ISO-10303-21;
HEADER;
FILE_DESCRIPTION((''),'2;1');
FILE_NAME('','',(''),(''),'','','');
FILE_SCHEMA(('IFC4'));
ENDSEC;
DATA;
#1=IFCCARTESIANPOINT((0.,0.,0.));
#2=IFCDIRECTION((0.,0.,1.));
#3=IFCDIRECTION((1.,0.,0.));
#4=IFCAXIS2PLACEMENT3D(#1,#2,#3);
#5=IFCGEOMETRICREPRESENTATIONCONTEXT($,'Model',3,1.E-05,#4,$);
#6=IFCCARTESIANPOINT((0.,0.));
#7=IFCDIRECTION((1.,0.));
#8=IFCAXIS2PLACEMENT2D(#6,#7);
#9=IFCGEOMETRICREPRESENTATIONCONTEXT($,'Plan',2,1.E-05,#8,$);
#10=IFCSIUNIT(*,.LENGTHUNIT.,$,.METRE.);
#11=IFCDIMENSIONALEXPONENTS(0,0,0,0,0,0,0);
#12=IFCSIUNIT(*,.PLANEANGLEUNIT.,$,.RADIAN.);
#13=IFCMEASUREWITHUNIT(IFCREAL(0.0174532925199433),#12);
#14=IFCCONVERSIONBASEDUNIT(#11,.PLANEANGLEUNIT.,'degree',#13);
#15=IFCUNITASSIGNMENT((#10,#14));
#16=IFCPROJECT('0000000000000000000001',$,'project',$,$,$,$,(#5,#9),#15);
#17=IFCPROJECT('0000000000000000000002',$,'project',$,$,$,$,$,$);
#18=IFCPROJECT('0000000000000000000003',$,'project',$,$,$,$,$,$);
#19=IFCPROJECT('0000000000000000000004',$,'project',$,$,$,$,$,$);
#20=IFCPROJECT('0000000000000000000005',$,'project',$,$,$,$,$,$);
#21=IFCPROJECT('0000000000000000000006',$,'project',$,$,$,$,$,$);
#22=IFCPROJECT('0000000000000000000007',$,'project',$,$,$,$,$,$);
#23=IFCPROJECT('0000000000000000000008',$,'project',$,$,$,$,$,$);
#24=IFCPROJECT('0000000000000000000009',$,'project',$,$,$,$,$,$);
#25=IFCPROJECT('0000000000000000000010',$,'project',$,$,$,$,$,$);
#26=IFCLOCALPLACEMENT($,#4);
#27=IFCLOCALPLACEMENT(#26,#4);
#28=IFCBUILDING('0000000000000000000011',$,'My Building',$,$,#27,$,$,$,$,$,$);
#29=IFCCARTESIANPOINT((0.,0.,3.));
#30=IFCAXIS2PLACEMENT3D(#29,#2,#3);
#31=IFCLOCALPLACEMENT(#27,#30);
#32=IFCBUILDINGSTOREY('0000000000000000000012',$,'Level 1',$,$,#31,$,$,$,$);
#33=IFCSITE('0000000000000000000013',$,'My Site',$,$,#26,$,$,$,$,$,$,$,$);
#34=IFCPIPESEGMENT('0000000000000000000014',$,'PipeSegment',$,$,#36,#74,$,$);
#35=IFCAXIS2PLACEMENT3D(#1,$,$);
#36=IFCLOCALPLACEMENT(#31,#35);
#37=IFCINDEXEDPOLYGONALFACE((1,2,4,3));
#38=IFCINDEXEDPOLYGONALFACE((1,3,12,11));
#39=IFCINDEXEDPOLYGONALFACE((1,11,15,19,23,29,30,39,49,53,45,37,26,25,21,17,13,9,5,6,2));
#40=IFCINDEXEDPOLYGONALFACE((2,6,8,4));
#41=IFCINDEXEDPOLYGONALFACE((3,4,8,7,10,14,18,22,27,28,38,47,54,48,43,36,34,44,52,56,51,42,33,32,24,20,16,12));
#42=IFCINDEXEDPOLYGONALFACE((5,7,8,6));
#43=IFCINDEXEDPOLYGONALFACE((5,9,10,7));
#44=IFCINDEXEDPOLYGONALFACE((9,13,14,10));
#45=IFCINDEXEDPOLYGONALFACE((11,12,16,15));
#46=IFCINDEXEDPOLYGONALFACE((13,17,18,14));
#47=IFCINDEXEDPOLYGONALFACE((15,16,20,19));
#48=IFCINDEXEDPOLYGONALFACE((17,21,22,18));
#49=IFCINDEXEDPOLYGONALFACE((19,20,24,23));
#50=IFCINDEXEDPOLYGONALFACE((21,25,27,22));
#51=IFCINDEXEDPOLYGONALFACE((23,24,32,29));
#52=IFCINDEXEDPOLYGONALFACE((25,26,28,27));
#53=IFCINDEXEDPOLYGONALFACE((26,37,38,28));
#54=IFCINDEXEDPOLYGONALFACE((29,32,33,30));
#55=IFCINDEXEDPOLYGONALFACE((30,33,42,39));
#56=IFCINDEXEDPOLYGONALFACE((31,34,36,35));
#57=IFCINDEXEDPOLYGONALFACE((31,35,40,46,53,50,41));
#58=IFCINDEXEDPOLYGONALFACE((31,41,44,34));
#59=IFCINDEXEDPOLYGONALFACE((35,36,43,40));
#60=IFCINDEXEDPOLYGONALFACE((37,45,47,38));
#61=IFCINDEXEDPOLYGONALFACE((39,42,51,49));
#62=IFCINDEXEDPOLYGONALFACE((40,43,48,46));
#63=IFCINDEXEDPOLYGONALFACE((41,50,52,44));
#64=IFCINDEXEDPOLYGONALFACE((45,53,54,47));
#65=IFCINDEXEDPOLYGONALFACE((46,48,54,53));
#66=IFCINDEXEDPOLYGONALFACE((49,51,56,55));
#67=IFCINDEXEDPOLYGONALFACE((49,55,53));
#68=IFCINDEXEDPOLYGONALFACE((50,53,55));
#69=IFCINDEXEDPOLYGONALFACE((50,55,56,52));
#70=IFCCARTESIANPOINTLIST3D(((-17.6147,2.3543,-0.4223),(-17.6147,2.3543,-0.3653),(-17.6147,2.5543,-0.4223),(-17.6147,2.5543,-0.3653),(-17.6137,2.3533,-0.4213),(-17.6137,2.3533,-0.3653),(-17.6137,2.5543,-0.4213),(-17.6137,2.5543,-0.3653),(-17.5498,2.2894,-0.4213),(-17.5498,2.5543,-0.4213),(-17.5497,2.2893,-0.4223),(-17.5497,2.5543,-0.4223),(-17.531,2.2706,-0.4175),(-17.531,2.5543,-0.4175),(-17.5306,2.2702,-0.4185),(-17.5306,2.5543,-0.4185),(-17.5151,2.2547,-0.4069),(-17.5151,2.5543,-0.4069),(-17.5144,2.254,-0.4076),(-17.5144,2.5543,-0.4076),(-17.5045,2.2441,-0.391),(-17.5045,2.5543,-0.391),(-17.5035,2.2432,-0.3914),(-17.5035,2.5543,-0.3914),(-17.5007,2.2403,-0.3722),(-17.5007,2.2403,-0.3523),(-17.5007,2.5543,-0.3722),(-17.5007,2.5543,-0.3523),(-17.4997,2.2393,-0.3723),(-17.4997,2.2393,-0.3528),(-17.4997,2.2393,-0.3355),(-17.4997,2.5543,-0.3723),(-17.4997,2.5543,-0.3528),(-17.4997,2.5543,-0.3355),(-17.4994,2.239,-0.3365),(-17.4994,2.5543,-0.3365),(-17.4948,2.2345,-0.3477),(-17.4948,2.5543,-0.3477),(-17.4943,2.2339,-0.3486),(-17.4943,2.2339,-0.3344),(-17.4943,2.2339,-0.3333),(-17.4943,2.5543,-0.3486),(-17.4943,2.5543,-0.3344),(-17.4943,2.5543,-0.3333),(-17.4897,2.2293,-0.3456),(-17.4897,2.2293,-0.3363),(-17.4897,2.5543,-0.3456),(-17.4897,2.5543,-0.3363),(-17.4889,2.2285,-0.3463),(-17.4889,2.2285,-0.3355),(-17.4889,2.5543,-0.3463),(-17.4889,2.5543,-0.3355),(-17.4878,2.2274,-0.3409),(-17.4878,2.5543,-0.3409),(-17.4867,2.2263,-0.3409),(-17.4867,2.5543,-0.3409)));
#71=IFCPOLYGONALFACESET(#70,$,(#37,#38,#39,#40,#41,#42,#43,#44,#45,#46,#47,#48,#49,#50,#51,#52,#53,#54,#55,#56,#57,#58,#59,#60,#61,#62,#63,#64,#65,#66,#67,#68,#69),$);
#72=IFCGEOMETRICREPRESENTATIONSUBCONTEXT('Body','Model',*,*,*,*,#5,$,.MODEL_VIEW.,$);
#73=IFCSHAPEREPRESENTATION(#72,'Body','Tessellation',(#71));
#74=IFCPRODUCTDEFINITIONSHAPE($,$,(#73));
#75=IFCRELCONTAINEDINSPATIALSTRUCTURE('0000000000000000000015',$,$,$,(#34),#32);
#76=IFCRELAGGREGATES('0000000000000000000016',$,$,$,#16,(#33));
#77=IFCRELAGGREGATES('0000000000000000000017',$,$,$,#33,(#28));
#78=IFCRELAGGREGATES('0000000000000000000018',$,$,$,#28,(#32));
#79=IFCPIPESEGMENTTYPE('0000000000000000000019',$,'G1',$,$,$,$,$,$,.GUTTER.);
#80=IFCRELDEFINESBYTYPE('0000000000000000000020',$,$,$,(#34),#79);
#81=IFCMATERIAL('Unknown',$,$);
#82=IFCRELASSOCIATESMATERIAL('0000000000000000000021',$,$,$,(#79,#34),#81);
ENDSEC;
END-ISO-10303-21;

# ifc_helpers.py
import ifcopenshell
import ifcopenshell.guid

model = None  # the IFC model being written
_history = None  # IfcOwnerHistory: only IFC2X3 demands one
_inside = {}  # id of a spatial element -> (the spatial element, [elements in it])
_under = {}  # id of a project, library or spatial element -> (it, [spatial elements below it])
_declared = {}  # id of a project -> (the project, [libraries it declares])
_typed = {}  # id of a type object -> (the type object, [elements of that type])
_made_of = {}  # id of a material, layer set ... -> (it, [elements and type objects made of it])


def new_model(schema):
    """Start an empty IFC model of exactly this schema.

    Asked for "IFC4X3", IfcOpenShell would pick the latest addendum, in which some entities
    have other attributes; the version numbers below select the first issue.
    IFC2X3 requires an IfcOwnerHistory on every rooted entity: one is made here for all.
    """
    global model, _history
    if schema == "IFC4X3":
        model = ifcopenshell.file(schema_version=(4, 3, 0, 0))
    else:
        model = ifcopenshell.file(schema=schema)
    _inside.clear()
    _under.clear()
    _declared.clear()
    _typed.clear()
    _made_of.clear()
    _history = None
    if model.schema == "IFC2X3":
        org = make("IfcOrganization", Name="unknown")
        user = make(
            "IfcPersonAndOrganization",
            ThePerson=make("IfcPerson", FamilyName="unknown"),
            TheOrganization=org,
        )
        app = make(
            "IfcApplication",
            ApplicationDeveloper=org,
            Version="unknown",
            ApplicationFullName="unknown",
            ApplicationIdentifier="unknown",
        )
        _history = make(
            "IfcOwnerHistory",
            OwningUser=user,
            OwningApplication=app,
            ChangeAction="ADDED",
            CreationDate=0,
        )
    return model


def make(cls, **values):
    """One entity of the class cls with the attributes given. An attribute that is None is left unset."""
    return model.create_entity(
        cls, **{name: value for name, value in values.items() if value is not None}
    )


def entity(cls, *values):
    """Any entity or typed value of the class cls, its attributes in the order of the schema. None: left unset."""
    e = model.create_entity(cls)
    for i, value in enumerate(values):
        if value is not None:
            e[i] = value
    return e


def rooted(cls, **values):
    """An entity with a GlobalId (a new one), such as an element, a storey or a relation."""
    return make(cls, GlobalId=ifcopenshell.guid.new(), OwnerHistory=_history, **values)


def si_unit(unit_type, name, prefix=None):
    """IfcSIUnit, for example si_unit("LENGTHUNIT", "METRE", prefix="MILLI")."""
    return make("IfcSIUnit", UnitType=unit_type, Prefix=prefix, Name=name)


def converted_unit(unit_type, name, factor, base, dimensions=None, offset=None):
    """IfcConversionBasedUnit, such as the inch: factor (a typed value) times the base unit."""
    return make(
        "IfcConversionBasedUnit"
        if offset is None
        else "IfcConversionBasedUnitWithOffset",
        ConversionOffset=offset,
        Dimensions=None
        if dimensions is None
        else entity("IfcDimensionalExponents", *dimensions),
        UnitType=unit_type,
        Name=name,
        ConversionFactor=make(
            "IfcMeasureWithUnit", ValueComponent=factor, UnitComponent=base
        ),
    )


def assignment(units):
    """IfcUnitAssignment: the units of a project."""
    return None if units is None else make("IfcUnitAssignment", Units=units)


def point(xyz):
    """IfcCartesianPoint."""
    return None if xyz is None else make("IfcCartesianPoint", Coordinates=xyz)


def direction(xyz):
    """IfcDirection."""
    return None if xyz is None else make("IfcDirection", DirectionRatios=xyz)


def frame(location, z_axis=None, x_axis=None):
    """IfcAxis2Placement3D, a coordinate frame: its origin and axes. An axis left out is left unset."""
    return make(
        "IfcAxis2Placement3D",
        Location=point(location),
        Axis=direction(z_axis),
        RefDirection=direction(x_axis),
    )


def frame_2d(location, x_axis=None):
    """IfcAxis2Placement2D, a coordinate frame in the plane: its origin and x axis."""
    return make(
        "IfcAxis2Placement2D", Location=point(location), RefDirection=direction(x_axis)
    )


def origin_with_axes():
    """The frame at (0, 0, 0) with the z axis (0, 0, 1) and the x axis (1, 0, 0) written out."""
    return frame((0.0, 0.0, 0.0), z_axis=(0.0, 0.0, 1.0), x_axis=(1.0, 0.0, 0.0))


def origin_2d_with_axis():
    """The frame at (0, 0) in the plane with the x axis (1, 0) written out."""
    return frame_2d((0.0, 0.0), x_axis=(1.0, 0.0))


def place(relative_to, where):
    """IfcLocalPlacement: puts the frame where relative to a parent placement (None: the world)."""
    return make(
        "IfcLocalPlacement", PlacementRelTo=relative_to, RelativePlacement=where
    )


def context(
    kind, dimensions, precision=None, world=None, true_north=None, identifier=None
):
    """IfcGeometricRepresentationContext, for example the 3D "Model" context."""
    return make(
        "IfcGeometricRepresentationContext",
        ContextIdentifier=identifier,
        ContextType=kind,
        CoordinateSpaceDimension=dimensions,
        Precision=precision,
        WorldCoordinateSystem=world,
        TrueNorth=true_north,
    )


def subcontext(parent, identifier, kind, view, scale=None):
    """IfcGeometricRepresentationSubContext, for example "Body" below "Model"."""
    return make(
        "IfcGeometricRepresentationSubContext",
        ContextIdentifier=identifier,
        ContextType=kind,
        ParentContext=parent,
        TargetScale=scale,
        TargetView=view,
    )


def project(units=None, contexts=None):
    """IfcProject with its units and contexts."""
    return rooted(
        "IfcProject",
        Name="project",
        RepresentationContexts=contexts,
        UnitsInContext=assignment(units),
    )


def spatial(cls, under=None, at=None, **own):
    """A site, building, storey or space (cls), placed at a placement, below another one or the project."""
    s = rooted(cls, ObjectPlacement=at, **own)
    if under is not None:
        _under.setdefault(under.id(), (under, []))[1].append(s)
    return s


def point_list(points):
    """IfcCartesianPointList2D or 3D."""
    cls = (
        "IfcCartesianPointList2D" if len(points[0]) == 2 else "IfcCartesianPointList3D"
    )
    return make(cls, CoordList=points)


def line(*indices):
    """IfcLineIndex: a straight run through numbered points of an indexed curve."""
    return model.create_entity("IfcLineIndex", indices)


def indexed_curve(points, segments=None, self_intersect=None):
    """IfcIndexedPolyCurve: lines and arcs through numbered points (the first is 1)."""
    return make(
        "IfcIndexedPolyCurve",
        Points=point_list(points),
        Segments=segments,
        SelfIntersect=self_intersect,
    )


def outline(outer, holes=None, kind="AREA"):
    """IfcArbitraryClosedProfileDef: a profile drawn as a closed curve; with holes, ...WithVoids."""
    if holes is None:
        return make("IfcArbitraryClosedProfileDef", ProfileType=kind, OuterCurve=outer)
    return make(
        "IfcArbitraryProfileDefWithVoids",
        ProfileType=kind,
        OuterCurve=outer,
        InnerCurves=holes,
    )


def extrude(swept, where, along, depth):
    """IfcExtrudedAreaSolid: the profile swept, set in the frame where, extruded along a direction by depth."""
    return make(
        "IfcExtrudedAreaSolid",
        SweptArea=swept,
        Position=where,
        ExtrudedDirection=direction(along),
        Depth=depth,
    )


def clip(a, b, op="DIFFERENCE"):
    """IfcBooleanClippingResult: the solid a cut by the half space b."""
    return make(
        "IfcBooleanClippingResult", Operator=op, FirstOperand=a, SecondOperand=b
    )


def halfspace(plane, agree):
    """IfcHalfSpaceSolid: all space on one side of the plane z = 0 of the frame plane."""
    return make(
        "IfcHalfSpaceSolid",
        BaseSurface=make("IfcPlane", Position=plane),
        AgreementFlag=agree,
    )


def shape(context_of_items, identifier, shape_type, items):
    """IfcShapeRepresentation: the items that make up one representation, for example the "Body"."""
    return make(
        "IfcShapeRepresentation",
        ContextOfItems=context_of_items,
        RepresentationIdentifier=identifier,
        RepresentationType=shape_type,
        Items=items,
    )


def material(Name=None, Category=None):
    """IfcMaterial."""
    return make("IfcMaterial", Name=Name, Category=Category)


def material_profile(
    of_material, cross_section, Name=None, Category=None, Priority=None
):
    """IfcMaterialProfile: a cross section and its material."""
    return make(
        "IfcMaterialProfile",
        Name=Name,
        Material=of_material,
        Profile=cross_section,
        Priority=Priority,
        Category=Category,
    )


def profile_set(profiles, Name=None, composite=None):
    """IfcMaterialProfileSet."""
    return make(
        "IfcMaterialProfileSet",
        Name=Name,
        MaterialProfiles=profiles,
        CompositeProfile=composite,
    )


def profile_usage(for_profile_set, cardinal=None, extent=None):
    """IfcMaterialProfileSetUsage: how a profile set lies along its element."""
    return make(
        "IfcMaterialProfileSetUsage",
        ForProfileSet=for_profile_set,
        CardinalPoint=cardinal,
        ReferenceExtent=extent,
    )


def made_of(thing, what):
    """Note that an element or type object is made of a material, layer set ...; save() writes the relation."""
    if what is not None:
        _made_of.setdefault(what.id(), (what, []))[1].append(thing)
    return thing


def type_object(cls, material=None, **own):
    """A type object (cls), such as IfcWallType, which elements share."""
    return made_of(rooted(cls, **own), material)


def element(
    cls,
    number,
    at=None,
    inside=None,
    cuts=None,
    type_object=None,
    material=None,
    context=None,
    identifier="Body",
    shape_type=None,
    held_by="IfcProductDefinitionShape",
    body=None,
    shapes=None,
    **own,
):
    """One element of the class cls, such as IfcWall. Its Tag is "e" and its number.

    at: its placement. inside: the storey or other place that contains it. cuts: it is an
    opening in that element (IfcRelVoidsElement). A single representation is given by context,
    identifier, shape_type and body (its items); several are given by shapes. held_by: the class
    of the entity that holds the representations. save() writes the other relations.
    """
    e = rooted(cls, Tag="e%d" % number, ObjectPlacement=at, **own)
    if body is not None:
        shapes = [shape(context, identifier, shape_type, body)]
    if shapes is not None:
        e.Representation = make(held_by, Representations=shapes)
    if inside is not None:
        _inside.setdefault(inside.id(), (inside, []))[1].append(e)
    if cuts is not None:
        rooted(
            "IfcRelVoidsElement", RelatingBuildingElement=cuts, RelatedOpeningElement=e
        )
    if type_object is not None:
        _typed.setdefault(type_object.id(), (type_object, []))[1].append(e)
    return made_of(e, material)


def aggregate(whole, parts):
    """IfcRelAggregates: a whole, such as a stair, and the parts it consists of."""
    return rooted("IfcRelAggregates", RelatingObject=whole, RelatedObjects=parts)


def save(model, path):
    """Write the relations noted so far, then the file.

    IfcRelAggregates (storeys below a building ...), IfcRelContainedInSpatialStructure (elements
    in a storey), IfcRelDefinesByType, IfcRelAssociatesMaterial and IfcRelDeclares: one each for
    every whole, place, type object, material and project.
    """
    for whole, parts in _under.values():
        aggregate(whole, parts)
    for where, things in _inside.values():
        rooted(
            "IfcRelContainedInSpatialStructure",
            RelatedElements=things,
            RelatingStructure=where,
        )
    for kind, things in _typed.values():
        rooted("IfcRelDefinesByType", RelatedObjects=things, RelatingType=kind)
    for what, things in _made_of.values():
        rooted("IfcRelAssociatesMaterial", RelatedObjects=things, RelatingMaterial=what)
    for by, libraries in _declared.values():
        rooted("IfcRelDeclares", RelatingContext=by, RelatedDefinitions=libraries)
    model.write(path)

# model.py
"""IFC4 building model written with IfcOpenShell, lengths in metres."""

from ifc_helpers import new_model, entity, si_unit, converted_unit, frame, origin_with_axes, origin_2d_with_axis, place, context, subcontext, project, spatial, line, indexed_curve, outline, extrude, clip, halfspace, material, material_profile, profile_set, profile_usage, type_object, element, save


model = new_model("IFC4")

# Units and contexts
model_context = context("Model", 3, precision=1e-05, world=origin_with_axes())
plan_context = context("Plan", 2, precision=1e-05, world=origin_2d_with_axis())
body_context_1 = subcontext(model_context, "Body", "Model", "MODEL_VIEW")
ifc_project_1 = project(units=[si_unit("LENGTHUNIT", "METRE"), converted_unit("PLANEANGLEUNIT", "degree", entity("IfcReal", 0.0174532925199433), si_unit("PLANEANGLEUNIT", "RADIAN"), dimensions=[0, 0, 0, 0, 0, 0, 0])], contexts=[model_context, plan_context])
ifc_project_2 = project()
ifc_project_3 = project()
ifc_project_4 = project()
ifc_project_5 = project()
ifc_project_6 = project()
ifc_project_7 = project()
ifc_project_8 = project()
ifc_project_9 = project()
ifc_project_10 = project()

# Site, building, storey
site_placement = place(None, origin_with_axes())
site = spatial("IfcSite", under=ifc_project_1, at=site_placement, Name="My Site")
building_placement = place(site_placement, origin_with_axes())
building = spatial("IfcBuilding", under=site, at=building_placement, Name="My Building")
storey_placement = place(building_placement, frame((0.0, 0.0, 3.0), z_axis=(0.0, 0.0, 1.0), x_axis=(1.0, 0.0, 0.0)))
storey = spatial("IfcBuildingStorey", under=building, at=storey_placement, Name="Level 1")

# Shared definitions
ifc_material = material(Name="Unknown")

# Pipe segment
ifc_material_profile = material_profile(ifc_material, outline(indexed_curve([(0.128, 0.0244), (0.1258, 0.0189), (0.1204, 0.0167), (0.115, 0.0125), (0.115, -0.007), (0.1112, -0.0261), (0.1004, -0.0424), (0.0841, -0.0532), (0.065, -0.057), (0.0, -0.057), (0.0, 0.0), (0.001, 0.0), (0.001, -0.056), (0.0649, -0.056), (0.0837, -0.0523), (0.0996, -0.0416), (0.1103, -0.0257), (0.114, -0.0069), (0.114, 0.013), (0.1199, 0.0176), (0.125, 0.0197), (0.127, 0.0244), (0.125, 0.029), (0.1204, 0.0309), (0.1153, 0.0288), (0.115, 0.0298), (0.1204, 0.032), (0.1258, 0.0298)], segments=[line(25, 24), line(24, 23), line(23, 22), line(22, 21), line(21, 20), line(20, 19), line(19, 18), line(18, 17), line(17, 16), line(16, 15), line(15, 14), line(14, 13), line(13, 12), line(12, 11), line(11, 10), line(10, 9), line(9, 8), line(8, 7), line(7, 6), line(6, 5), line(5, 4), line(4, 3), line(3, 2), line(2, 1), line(1, 28), line(28, 27), line(27, 26), line(26, 25)], self_intersect=False)))
ifc_profile_set = profile_set([ifc_material_profile], Name="Gutter-115")
ifc_profile_usage = profile_usage(ifc_profile_set, cardinal=5)
pipe_segment_type = type_object("IfcPipeSegmentType", Name="G1", PredefinedType="GUTTER", material=ifc_profile_set)
pipe_segment_placement = place(storey_placement, frame((-17.6147, 2.5543, -0.3653), z_axis=(0.0, -1.0, 0.0), x_axis=(1.0, 0.0, 0.0)))
element("IfcPipeSegment", 1, at=pipe_segment_placement, inside=storey, type_object=pipe_segment_type, material=ifc_profile_usage, Name="PipeSegment", context=body_context_1, shape_type="Clipping", body=[
    clip(extrude(outline(indexed_curve([(0.128, 0.0244), (0.1258, 0.0189), (0.1204, 0.0167), (0.115, 0.0125), (0.115, -0.007), (0.1112, -0.0261), (0.1004, -0.0424), (0.0841, -0.0532), (0.065, -0.057), (0.0, -0.057), (0.0, 0.0), (0.001, 0.0), (0.001, -0.056), (0.0649, -0.056), (0.0837, -0.0523), (0.0996, -0.0416), (0.1103, -0.0257), (0.114, -0.0069), (0.114, 0.013), (0.1199, 0.0176), (0.125, 0.0197), (0.127, 0.0244), (0.125, 0.029), (0.1204, 0.0309), (0.1153, 0.0288), (0.115, 0.0298), (0.1204, 0.032), (0.1258, 0.0298)], segments=[line(25, 24), line(24, 23), line(23, 22), line(22, 21), line(21, 20), line(20, 19), line(19, 18), line(18, 17), line(17, 16), line(16, 15), line(15, 14), line(14, 13), line(13, 12), line(12, 11), line(11, 10), line(10, 9), line(9, 8), line(8, 7), line(7, 6), line(6, 5), line(5, 4), line(4, 3), line(3, 2), line(2, 1), line(1, 28), line(28, 27), line(27, 26), line(26, 25)], self_intersect=False)), origin_with_axes(), (0.0, 0.0, 1.0), 0.328), halfspace(frame((0.1281, -2.6347, 0.328), z_axis=(-0.707107, 0.0, 0.707107), x_axis=(-0.707107, 0.0, -0.707107)), False)),
])

save(model, "model.ifc")
